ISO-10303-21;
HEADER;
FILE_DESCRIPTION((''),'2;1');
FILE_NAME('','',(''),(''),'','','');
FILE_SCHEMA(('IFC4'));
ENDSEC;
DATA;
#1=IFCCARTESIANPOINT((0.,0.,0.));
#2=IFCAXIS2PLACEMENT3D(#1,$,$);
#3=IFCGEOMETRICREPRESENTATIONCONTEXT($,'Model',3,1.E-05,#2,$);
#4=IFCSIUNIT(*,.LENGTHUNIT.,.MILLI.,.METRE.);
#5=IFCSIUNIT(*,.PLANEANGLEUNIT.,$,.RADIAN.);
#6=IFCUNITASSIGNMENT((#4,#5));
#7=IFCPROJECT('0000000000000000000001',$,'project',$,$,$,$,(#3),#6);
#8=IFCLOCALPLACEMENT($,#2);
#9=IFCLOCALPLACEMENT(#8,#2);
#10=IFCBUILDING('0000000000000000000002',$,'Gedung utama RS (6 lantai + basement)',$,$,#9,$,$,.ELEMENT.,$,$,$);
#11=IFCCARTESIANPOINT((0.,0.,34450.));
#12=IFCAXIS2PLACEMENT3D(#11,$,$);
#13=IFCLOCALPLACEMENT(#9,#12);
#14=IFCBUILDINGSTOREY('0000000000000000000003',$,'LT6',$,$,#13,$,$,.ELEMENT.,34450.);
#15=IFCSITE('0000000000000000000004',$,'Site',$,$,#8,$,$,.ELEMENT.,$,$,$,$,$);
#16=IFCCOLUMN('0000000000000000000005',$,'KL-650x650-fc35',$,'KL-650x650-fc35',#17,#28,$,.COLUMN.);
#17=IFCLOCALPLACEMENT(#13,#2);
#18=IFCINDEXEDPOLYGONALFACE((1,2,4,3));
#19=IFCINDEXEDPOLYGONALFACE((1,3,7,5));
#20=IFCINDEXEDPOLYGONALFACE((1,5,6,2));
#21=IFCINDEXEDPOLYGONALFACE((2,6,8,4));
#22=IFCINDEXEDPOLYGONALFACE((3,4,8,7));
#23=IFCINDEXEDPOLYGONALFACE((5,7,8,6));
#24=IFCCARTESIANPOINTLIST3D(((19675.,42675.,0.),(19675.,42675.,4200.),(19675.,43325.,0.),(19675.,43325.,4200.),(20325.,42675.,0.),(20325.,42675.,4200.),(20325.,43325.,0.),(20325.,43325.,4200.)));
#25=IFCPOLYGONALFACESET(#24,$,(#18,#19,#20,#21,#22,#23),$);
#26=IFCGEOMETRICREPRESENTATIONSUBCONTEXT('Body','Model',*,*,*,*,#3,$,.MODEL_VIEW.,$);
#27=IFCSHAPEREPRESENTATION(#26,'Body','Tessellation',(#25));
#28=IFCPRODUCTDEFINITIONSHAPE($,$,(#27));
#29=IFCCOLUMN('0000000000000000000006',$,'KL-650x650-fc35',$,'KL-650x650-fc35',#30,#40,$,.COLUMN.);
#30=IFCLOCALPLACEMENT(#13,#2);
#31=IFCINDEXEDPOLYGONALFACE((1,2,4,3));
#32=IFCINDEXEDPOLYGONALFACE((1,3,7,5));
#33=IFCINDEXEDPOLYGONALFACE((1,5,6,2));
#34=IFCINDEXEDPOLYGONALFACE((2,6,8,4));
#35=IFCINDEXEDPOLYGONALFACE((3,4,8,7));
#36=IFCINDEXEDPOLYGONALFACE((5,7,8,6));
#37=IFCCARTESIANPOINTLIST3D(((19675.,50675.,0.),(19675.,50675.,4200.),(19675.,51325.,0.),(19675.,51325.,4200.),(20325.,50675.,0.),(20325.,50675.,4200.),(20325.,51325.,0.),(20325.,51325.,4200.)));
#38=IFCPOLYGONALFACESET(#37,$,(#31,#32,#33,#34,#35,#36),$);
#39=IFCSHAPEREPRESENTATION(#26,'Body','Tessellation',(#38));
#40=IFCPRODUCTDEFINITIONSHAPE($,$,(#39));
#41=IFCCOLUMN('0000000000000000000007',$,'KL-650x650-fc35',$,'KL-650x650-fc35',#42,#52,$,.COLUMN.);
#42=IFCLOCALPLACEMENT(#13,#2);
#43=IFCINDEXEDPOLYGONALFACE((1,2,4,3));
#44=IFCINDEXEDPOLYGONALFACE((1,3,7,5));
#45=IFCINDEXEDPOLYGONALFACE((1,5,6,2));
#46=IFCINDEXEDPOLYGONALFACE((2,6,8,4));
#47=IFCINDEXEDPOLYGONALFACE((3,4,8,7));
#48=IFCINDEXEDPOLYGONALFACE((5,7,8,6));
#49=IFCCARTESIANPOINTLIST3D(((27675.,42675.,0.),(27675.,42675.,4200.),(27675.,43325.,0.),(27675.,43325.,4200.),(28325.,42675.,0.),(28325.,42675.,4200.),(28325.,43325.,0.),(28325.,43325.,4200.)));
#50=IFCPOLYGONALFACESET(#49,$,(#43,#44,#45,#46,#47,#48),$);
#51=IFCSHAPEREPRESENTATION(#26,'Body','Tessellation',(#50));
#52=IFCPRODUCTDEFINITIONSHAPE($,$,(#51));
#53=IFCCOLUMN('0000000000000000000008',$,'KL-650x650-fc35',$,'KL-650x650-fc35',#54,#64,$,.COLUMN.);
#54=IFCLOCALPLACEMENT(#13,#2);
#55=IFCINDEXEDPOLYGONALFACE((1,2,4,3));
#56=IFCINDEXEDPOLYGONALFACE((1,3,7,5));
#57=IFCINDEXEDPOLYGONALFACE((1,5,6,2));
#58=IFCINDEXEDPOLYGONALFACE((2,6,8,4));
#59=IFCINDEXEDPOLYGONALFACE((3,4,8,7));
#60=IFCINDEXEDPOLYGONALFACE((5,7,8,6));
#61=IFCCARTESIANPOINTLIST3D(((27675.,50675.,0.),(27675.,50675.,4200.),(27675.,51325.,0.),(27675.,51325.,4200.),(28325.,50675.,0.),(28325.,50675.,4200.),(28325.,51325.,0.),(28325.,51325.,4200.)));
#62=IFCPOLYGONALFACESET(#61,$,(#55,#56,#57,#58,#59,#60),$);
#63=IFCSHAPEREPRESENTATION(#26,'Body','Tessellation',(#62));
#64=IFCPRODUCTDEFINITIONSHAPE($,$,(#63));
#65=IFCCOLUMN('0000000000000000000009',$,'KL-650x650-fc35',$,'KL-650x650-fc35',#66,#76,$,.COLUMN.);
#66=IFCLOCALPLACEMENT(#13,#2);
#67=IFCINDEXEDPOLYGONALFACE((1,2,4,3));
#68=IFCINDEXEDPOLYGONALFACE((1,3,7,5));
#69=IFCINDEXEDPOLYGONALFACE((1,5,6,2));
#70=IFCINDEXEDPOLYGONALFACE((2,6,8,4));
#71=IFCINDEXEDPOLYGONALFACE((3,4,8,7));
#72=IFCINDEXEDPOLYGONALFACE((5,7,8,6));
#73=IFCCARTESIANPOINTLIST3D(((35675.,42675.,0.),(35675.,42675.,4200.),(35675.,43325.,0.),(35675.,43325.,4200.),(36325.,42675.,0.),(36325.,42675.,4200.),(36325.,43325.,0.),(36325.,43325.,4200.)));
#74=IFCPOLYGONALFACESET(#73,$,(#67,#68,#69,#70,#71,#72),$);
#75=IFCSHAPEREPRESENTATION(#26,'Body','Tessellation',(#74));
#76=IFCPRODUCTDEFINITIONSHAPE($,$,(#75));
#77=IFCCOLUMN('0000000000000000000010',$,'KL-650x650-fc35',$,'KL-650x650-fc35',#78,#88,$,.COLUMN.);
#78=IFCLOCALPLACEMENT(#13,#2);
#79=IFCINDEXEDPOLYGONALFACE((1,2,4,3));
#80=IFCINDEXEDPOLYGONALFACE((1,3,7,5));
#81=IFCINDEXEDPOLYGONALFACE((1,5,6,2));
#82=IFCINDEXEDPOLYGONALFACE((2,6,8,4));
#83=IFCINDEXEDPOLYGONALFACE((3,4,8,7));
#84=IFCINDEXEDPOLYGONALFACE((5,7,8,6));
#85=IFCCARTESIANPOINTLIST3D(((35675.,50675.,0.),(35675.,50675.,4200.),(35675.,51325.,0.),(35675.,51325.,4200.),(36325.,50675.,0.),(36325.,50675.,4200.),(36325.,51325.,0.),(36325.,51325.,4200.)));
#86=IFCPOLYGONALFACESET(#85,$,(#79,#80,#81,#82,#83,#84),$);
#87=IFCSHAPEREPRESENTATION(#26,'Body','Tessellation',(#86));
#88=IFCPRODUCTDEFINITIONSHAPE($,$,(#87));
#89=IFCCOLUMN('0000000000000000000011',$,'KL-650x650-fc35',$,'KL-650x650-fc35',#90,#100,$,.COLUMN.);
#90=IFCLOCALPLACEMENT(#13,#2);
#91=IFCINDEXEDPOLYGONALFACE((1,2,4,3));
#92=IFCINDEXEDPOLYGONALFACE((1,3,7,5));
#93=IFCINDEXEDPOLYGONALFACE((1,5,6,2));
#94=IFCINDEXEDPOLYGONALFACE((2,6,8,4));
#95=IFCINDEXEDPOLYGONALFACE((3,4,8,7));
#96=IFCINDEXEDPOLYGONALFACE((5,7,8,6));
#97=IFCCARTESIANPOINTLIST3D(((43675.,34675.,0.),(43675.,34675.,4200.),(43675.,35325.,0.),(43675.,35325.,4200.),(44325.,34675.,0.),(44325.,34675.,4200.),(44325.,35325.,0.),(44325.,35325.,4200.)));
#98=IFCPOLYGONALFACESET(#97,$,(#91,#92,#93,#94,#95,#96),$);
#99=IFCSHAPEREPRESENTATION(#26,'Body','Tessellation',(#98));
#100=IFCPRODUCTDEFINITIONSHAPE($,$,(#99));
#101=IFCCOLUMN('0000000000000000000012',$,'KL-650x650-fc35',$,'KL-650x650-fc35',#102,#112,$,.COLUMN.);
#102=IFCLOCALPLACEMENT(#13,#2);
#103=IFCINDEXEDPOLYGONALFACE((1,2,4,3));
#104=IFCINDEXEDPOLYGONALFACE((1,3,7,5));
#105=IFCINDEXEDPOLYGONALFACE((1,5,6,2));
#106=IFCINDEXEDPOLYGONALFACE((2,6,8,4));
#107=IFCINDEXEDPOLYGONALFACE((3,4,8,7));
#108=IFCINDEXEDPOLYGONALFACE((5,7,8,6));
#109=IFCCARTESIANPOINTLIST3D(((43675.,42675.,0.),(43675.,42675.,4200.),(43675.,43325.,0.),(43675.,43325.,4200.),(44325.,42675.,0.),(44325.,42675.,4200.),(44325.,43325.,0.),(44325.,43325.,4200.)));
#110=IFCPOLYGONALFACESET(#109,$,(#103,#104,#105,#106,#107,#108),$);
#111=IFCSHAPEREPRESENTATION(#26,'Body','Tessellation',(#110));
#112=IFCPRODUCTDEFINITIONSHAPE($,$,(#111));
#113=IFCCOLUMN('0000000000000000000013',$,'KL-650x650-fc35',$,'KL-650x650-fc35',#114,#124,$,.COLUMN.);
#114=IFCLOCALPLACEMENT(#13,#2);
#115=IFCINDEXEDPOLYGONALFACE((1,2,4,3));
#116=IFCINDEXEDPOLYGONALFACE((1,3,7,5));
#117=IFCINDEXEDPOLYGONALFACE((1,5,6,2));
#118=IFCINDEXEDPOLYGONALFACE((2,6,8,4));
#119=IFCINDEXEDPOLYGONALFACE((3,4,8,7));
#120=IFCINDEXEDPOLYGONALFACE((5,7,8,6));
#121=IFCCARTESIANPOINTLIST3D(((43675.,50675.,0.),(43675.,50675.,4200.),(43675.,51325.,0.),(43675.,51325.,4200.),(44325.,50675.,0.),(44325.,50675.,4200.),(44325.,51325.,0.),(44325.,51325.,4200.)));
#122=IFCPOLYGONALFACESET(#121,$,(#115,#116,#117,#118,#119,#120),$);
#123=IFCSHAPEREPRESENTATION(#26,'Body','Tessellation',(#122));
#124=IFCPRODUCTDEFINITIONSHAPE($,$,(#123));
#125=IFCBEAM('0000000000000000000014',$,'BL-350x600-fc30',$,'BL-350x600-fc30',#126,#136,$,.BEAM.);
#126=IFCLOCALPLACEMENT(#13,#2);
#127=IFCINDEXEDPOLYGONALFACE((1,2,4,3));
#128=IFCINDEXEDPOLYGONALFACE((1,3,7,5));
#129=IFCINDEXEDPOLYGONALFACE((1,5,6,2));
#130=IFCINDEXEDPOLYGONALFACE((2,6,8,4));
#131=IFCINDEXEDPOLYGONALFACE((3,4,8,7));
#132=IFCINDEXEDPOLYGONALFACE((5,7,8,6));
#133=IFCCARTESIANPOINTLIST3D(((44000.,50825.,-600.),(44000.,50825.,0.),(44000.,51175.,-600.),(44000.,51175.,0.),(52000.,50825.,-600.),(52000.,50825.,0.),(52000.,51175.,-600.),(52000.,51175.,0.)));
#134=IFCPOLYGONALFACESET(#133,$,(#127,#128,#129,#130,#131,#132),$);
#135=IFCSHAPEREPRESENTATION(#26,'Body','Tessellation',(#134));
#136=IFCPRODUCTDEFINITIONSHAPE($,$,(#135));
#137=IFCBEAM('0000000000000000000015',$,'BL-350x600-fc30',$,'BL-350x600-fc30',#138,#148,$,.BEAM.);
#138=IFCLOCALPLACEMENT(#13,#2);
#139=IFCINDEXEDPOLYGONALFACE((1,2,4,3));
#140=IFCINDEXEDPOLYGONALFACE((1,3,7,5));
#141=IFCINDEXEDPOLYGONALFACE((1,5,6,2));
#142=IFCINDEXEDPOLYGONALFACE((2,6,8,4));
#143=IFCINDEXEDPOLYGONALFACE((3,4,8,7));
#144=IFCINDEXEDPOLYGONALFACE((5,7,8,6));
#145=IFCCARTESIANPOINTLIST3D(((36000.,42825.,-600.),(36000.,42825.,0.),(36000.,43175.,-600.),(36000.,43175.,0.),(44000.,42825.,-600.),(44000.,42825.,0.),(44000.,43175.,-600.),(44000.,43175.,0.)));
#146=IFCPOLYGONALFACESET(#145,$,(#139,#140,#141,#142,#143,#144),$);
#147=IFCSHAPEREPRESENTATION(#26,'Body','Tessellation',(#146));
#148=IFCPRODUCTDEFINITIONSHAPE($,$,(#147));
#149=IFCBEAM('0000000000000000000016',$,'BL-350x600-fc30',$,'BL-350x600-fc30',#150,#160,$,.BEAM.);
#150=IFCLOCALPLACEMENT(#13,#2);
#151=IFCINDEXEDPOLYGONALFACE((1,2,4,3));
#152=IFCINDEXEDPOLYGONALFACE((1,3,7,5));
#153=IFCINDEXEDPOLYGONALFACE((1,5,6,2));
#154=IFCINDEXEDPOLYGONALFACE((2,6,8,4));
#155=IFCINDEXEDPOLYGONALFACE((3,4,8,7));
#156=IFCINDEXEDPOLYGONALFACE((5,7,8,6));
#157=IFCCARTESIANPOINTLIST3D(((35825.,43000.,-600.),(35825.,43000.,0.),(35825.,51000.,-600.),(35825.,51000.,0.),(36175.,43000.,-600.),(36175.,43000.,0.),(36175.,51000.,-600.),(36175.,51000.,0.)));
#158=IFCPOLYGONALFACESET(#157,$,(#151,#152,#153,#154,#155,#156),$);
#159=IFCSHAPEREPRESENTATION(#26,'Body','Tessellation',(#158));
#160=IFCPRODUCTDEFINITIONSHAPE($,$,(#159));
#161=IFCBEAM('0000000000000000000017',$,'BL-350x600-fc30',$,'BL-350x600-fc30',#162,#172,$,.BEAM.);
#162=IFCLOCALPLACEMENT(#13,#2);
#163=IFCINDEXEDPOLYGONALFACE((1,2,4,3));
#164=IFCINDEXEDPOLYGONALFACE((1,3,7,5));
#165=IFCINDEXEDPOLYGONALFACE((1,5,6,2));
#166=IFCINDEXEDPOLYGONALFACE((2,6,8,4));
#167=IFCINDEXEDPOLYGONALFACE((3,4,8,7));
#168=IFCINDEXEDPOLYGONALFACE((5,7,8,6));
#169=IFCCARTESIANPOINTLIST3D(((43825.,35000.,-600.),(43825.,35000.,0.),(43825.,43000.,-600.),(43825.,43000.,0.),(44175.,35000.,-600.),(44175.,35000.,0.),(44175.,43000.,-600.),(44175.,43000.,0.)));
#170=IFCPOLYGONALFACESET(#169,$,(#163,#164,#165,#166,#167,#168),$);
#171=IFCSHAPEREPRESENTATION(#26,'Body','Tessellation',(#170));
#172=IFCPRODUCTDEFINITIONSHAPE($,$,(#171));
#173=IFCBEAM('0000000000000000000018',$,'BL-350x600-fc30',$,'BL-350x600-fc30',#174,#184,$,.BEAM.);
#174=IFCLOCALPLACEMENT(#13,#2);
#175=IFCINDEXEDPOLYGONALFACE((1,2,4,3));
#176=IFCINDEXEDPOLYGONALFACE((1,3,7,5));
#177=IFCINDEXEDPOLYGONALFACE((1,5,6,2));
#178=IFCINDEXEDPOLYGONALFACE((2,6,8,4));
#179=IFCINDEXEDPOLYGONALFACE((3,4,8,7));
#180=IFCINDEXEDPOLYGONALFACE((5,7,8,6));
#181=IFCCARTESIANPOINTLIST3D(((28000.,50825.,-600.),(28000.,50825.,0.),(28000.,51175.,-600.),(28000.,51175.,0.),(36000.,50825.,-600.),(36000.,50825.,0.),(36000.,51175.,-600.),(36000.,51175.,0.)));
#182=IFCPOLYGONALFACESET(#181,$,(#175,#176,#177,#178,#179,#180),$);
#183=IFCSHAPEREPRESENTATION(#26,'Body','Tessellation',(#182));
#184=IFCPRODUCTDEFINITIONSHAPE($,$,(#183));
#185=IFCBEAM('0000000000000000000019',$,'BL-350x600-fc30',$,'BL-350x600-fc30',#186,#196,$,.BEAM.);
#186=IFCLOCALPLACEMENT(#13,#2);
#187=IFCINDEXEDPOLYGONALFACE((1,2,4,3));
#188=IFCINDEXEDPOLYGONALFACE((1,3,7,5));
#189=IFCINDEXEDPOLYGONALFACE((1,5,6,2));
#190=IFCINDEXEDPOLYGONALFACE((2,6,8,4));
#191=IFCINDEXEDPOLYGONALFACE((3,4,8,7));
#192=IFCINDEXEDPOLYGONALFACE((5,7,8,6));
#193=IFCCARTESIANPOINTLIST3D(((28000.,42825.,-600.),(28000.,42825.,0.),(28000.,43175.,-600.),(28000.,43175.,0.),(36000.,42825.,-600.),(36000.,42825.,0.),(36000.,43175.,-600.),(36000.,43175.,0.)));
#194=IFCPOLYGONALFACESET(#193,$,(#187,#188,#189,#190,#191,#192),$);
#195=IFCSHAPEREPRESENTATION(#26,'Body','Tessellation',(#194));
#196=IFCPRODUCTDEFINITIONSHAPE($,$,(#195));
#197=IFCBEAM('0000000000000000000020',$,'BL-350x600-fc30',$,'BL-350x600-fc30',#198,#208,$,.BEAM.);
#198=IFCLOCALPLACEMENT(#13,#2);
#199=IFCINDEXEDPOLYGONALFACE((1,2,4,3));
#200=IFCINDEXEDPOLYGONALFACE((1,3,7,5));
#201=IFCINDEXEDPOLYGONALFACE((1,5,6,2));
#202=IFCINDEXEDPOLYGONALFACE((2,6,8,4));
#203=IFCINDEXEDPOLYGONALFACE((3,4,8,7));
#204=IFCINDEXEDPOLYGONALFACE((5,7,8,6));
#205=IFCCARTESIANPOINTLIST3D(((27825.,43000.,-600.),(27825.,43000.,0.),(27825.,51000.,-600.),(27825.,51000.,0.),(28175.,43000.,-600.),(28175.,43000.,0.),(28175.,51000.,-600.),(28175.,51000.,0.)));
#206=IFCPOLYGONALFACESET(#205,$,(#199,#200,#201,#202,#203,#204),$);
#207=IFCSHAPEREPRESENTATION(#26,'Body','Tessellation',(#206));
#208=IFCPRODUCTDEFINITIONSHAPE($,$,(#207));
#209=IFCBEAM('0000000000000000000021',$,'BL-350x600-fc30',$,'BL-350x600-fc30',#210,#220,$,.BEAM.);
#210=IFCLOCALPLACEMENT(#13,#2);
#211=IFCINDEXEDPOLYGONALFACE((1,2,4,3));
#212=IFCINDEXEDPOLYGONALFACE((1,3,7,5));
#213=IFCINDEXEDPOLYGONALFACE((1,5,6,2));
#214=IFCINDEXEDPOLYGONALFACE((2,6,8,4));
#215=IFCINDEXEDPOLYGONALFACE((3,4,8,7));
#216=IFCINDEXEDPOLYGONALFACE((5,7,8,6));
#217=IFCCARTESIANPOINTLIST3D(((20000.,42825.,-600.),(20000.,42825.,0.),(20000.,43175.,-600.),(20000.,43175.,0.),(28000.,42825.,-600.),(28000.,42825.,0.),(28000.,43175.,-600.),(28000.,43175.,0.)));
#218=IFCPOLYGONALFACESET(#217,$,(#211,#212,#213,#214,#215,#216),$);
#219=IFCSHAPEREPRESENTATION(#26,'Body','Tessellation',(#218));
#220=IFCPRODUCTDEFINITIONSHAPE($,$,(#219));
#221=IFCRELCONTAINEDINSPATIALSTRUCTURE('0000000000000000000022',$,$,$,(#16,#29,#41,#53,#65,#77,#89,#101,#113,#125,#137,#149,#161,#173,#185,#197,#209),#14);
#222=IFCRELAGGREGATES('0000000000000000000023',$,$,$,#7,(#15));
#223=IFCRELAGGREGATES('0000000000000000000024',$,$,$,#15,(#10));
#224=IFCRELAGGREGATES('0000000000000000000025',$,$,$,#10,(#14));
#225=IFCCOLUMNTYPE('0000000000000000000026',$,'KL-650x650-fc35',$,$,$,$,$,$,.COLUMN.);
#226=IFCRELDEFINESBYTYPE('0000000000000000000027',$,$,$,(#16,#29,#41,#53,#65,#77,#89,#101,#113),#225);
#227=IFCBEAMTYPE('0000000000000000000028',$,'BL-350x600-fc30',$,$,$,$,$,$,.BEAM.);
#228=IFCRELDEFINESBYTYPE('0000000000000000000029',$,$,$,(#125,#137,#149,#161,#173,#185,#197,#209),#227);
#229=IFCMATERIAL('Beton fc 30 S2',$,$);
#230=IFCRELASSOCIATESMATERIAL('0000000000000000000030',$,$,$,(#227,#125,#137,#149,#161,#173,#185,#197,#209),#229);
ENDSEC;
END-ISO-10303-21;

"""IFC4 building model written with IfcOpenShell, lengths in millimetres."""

from ifc_helpers import new_model, si_unit, frame, origin, origin_2d, place, context, subcontext, project, spatial, rectangle, extrude, material, material_profile, profile_set, profile_usage, type_object, element, save


model = new_model("IFC4")

# Units and contexts
model_context = context("Model", 3, precision=1e-05, world=origin())
body_context = subcontext(model_context, "Body", "Model", "MODEL_VIEW")
ifc_project = project(units=[si_unit("LENGTHUNIT", "METRE", prefix="MILLI"), si_unit("PLANEANGLEUNIT", "RADIAN")], contexts=[model_context])

# Site, building, storey
site_placement = place(None, origin())
site = spatial("IfcSite", under=ifc_project, at=site_placement, Name="Site", CompositionType="ELEMENT")
building_placement = place(site_placement, origin())
building = spatial("IfcBuilding", under=site, at=building_placement, Name="Gedung utama RS (6 lantai + basement)", CompositionType="ELEMENT")
storey_placement = place(building_placement, frame((0.0, 0.0, 34450.0)))
storey = spatial("IfcBuildingStorey", under=building, at=storey_placement, Name="LT6", CompositionType="ELEMENT", Elevation=34450.0)

# Columns
ifc_material_profile_1 = material_profile(None, rectangle(XDim=650.0, YDim=650.0, at=origin_2d()), Name="KL-650x650-fc35")
ifc_profile_set_1 = profile_set([ifc_material_profile_1], Name="KL-650x650-fc35")
ifc_profile_usage_1 = profile_usage(ifc_profile_set_1, cardinal=5)
column_type = type_object("IfcColumnType", Name="KL-650x650-fc35", PredefinedType="COLUMN", material=ifc_profile_set_1)
for number, where, z_axis, x_axis, name in (
    (1, (20000.0, 43000.0, 0.0), (0.0, 0.0, 1.0), (1.0, 0.0, 0.0), "KL-650x650-fc35"),
    (2, (20000.0, 51000.0, 0.0), (0.0, 0.0, 1.0), (1.0, 0.0, 0.0), "KL-650x650-fc35"),
    (3, (28000.0, 43000.0, 0.0), (0.0, 0.0, 1.0), (1.0, 0.0, 0.0), "KL-650x650-fc35"),
    (4, (28000.0, 51000.0, 0.0), (0.0, 0.0, 1.0), (1.0, 0.0, 0.0), "KL-650x650-fc35"),
    (5, (36000.0, 43000.0, 0.0), (0.0, 0.0, 1.0), (1.0, 0.0, 0.0), "KL-650x650-fc35"),
    (6, (36000.0, 51000.0, 0.0), (0.0, 0.0, 1.0), (1.0, 0.0, 0.0), "KL-650x650-fc35"),
    (7, (44000.0, 35000.0, 0.0), (0.0, 0.0, 1.0), (1.0, 0.0, 0.0), "KL-650x650-fc35"),
    (8, (44000.0, 43000.0, 0.0), (0.0, 0.0, 1.0), (1.0, 0.0, 0.0), "KL-650x650-fc35"),
    (9, (44000.0, 51000.0, 0.0), (0.0, 0.0, 1.0), (1.0, 0.0, 0.0), "KL-650x650-fc35"),
):
    element("IfcColumn", number, at=place(storey_placement, frame(where, z_axis=z_axis, x_axis=x_axis)), inside=storey, type_object=column_type, material=ifc_profile_usage_1, Name=name, ObjectType="KL-650x650-fc35", PredefinedType="COLUMN", context=body_context, shape_type="SweptSolid", body=[
        extrude(rectangle(XDim=650.0, YDim=650.0, at=origin_2d()), origin(), (0.0, 0.0, 1.0), 4200.0),
    ])

# Beams
ifc_material_1 = material(Name="Beton fc 30 S2")
ifc_material_profile_2 = material_profile(ifc_material_1, rectangle(XDim=350.0, YDim=600.0, at=origin_2d()), Name="BL-350x600-fc30")
ifc_profile_set_2 = profile_set([ifc_material_profile_2], Name="BL-350x600-fc30")
ifc_profile_usage_2 = profile_usage(ifc_profile_set_2, cardinal=8)
beam_type = type_object("IfcBeamType", Name="BL-350x600-fc30", PredefinedType="BEAM", material=ifc_profile_set_2)
for number, where, name in (
    (10, (44000.0, 51000.0, -300.0), "BL-350x600-fc30"),
    (11, (36000.0, 43000.0, -300.0), "BL-350x600-fc30"),
):
    element("IfcBeam", number, at=place(storey_placement, frame(where)), inside=storey, type_object=beam_type, material=ifc_profile_usage_2, Name=name, ObjectType="BL-350x600-fc30", PredefinedType="BEAM", context=body_context, shape_type="SweptSolid", body=[
        extrude(rectangle(XDim=350.0, YDim=600.0, at=origin_2d()), frame((0.0, 0.0, 0.0), z_axis=(1.0, 0.0, 0.0), x_axis=(0.0, 1.0, 0.0)), (0.0, 0.0, 1.0), 8000.0),
    ])
for number, where, name in (
    (12, (36000.0, 43000.0, -300.0), "BL-350x600-fc30"),
    (13, (44000.0, 35000.0, -300.0), "BL-350x600-fc30"),
):
    element("IfcBeam", number, at=place(storey_placement, frame(where)), inside=storey, type_object=beam_type, material=ifc_profile_usage_2, Name=name, ObjectType="BL-350x600-fc30", PredefinedType="BEAM", context=body_context, shape_type="SweptSolid", body=[
        extrude(rectangle(XDim=350.0, YDim=600.0, at=origin_2d()), frame((0.0, 0.0, 0.0), z_axis=(0.0, 1.0, 0.0), x_axis=(-1.0, 0.0, 0.0)), (0.0, 0.0, 1.0), 8000.0),
    ])
for number, where, name in (
    (14, (28000.0, 51000.0, -300.0), "BL-350x600-fc30"),
    (15, (28000.0, 43000.0, -300.0), "BL-350x600-fc30"),
):
    element("IfcBeam", number, at=place(storey_placement, frame(where)), inside=storey, type_object=beam_type, material=ifc_profile_usage_2, Name=name, ObjectType="BL-350x600-fc30", PredefinedType="BEAM", context=body_context, shape_type="SweptSolid", body=[
        extrude(rectangle(XDim=350.0, YDim=600.0, at=origin_2d()), frame((0.0, 0.0, 0.0), z_axis=(1.0, 0.0, 0.0), x_axis=(0.0, 1.0, 0.0)), (0.0, 0.0, 1.0), 8000.0),
    ])
beam_1_placement = place(storey_placement, frame((28000.0, 43000.0, -300.0)))
element("IfcBeam", 16, at=beam_1_placement, inside=storey, type_object=beam_type, material=ifc_profile_usage_2, Name="BL-350x600-fc30", ObjectType="BL-350x600-fc30", PredefinedType="BEAM", context=body_context, shape_type="SweptSolid", body=[
    extrude(rectangle(XDim=350.0, YDim=600.0, at=origin_2d()), frame((0.0, 0.0, 0.0), z_axis=(0.0, 1.0, 0.0), x_axis=(-1.0, 0.0, 0.0)), (0.0, 0.0, 1.0), 8000.0),
])
beam_2_placement = place(storey_placement, frame((20000.0, 43000.0, -300.0)))
element("IfcBeam", 17, at=beam_2_placement, inside=storey, type_object=beam_type, material=ifc_profile_usage_2, Name="BL-350x600-fc30", ObjectType="BL-350x600-fc30", PredefinedType="BEAM", context=body_context, shape_type="SweptSolid", body=[
    extrude(rectangle(XDim=350.0, YDim=600.0, at=origin_2d()), frame((0.0, 0.0, 0.0), z_axis=(1.0, 0.0, 0.0), x_axis=(0.0, 1.0, 0.0)), (0.0, 0.0, 1.0), 8000.0),
])

save(model, "model.ifc")
